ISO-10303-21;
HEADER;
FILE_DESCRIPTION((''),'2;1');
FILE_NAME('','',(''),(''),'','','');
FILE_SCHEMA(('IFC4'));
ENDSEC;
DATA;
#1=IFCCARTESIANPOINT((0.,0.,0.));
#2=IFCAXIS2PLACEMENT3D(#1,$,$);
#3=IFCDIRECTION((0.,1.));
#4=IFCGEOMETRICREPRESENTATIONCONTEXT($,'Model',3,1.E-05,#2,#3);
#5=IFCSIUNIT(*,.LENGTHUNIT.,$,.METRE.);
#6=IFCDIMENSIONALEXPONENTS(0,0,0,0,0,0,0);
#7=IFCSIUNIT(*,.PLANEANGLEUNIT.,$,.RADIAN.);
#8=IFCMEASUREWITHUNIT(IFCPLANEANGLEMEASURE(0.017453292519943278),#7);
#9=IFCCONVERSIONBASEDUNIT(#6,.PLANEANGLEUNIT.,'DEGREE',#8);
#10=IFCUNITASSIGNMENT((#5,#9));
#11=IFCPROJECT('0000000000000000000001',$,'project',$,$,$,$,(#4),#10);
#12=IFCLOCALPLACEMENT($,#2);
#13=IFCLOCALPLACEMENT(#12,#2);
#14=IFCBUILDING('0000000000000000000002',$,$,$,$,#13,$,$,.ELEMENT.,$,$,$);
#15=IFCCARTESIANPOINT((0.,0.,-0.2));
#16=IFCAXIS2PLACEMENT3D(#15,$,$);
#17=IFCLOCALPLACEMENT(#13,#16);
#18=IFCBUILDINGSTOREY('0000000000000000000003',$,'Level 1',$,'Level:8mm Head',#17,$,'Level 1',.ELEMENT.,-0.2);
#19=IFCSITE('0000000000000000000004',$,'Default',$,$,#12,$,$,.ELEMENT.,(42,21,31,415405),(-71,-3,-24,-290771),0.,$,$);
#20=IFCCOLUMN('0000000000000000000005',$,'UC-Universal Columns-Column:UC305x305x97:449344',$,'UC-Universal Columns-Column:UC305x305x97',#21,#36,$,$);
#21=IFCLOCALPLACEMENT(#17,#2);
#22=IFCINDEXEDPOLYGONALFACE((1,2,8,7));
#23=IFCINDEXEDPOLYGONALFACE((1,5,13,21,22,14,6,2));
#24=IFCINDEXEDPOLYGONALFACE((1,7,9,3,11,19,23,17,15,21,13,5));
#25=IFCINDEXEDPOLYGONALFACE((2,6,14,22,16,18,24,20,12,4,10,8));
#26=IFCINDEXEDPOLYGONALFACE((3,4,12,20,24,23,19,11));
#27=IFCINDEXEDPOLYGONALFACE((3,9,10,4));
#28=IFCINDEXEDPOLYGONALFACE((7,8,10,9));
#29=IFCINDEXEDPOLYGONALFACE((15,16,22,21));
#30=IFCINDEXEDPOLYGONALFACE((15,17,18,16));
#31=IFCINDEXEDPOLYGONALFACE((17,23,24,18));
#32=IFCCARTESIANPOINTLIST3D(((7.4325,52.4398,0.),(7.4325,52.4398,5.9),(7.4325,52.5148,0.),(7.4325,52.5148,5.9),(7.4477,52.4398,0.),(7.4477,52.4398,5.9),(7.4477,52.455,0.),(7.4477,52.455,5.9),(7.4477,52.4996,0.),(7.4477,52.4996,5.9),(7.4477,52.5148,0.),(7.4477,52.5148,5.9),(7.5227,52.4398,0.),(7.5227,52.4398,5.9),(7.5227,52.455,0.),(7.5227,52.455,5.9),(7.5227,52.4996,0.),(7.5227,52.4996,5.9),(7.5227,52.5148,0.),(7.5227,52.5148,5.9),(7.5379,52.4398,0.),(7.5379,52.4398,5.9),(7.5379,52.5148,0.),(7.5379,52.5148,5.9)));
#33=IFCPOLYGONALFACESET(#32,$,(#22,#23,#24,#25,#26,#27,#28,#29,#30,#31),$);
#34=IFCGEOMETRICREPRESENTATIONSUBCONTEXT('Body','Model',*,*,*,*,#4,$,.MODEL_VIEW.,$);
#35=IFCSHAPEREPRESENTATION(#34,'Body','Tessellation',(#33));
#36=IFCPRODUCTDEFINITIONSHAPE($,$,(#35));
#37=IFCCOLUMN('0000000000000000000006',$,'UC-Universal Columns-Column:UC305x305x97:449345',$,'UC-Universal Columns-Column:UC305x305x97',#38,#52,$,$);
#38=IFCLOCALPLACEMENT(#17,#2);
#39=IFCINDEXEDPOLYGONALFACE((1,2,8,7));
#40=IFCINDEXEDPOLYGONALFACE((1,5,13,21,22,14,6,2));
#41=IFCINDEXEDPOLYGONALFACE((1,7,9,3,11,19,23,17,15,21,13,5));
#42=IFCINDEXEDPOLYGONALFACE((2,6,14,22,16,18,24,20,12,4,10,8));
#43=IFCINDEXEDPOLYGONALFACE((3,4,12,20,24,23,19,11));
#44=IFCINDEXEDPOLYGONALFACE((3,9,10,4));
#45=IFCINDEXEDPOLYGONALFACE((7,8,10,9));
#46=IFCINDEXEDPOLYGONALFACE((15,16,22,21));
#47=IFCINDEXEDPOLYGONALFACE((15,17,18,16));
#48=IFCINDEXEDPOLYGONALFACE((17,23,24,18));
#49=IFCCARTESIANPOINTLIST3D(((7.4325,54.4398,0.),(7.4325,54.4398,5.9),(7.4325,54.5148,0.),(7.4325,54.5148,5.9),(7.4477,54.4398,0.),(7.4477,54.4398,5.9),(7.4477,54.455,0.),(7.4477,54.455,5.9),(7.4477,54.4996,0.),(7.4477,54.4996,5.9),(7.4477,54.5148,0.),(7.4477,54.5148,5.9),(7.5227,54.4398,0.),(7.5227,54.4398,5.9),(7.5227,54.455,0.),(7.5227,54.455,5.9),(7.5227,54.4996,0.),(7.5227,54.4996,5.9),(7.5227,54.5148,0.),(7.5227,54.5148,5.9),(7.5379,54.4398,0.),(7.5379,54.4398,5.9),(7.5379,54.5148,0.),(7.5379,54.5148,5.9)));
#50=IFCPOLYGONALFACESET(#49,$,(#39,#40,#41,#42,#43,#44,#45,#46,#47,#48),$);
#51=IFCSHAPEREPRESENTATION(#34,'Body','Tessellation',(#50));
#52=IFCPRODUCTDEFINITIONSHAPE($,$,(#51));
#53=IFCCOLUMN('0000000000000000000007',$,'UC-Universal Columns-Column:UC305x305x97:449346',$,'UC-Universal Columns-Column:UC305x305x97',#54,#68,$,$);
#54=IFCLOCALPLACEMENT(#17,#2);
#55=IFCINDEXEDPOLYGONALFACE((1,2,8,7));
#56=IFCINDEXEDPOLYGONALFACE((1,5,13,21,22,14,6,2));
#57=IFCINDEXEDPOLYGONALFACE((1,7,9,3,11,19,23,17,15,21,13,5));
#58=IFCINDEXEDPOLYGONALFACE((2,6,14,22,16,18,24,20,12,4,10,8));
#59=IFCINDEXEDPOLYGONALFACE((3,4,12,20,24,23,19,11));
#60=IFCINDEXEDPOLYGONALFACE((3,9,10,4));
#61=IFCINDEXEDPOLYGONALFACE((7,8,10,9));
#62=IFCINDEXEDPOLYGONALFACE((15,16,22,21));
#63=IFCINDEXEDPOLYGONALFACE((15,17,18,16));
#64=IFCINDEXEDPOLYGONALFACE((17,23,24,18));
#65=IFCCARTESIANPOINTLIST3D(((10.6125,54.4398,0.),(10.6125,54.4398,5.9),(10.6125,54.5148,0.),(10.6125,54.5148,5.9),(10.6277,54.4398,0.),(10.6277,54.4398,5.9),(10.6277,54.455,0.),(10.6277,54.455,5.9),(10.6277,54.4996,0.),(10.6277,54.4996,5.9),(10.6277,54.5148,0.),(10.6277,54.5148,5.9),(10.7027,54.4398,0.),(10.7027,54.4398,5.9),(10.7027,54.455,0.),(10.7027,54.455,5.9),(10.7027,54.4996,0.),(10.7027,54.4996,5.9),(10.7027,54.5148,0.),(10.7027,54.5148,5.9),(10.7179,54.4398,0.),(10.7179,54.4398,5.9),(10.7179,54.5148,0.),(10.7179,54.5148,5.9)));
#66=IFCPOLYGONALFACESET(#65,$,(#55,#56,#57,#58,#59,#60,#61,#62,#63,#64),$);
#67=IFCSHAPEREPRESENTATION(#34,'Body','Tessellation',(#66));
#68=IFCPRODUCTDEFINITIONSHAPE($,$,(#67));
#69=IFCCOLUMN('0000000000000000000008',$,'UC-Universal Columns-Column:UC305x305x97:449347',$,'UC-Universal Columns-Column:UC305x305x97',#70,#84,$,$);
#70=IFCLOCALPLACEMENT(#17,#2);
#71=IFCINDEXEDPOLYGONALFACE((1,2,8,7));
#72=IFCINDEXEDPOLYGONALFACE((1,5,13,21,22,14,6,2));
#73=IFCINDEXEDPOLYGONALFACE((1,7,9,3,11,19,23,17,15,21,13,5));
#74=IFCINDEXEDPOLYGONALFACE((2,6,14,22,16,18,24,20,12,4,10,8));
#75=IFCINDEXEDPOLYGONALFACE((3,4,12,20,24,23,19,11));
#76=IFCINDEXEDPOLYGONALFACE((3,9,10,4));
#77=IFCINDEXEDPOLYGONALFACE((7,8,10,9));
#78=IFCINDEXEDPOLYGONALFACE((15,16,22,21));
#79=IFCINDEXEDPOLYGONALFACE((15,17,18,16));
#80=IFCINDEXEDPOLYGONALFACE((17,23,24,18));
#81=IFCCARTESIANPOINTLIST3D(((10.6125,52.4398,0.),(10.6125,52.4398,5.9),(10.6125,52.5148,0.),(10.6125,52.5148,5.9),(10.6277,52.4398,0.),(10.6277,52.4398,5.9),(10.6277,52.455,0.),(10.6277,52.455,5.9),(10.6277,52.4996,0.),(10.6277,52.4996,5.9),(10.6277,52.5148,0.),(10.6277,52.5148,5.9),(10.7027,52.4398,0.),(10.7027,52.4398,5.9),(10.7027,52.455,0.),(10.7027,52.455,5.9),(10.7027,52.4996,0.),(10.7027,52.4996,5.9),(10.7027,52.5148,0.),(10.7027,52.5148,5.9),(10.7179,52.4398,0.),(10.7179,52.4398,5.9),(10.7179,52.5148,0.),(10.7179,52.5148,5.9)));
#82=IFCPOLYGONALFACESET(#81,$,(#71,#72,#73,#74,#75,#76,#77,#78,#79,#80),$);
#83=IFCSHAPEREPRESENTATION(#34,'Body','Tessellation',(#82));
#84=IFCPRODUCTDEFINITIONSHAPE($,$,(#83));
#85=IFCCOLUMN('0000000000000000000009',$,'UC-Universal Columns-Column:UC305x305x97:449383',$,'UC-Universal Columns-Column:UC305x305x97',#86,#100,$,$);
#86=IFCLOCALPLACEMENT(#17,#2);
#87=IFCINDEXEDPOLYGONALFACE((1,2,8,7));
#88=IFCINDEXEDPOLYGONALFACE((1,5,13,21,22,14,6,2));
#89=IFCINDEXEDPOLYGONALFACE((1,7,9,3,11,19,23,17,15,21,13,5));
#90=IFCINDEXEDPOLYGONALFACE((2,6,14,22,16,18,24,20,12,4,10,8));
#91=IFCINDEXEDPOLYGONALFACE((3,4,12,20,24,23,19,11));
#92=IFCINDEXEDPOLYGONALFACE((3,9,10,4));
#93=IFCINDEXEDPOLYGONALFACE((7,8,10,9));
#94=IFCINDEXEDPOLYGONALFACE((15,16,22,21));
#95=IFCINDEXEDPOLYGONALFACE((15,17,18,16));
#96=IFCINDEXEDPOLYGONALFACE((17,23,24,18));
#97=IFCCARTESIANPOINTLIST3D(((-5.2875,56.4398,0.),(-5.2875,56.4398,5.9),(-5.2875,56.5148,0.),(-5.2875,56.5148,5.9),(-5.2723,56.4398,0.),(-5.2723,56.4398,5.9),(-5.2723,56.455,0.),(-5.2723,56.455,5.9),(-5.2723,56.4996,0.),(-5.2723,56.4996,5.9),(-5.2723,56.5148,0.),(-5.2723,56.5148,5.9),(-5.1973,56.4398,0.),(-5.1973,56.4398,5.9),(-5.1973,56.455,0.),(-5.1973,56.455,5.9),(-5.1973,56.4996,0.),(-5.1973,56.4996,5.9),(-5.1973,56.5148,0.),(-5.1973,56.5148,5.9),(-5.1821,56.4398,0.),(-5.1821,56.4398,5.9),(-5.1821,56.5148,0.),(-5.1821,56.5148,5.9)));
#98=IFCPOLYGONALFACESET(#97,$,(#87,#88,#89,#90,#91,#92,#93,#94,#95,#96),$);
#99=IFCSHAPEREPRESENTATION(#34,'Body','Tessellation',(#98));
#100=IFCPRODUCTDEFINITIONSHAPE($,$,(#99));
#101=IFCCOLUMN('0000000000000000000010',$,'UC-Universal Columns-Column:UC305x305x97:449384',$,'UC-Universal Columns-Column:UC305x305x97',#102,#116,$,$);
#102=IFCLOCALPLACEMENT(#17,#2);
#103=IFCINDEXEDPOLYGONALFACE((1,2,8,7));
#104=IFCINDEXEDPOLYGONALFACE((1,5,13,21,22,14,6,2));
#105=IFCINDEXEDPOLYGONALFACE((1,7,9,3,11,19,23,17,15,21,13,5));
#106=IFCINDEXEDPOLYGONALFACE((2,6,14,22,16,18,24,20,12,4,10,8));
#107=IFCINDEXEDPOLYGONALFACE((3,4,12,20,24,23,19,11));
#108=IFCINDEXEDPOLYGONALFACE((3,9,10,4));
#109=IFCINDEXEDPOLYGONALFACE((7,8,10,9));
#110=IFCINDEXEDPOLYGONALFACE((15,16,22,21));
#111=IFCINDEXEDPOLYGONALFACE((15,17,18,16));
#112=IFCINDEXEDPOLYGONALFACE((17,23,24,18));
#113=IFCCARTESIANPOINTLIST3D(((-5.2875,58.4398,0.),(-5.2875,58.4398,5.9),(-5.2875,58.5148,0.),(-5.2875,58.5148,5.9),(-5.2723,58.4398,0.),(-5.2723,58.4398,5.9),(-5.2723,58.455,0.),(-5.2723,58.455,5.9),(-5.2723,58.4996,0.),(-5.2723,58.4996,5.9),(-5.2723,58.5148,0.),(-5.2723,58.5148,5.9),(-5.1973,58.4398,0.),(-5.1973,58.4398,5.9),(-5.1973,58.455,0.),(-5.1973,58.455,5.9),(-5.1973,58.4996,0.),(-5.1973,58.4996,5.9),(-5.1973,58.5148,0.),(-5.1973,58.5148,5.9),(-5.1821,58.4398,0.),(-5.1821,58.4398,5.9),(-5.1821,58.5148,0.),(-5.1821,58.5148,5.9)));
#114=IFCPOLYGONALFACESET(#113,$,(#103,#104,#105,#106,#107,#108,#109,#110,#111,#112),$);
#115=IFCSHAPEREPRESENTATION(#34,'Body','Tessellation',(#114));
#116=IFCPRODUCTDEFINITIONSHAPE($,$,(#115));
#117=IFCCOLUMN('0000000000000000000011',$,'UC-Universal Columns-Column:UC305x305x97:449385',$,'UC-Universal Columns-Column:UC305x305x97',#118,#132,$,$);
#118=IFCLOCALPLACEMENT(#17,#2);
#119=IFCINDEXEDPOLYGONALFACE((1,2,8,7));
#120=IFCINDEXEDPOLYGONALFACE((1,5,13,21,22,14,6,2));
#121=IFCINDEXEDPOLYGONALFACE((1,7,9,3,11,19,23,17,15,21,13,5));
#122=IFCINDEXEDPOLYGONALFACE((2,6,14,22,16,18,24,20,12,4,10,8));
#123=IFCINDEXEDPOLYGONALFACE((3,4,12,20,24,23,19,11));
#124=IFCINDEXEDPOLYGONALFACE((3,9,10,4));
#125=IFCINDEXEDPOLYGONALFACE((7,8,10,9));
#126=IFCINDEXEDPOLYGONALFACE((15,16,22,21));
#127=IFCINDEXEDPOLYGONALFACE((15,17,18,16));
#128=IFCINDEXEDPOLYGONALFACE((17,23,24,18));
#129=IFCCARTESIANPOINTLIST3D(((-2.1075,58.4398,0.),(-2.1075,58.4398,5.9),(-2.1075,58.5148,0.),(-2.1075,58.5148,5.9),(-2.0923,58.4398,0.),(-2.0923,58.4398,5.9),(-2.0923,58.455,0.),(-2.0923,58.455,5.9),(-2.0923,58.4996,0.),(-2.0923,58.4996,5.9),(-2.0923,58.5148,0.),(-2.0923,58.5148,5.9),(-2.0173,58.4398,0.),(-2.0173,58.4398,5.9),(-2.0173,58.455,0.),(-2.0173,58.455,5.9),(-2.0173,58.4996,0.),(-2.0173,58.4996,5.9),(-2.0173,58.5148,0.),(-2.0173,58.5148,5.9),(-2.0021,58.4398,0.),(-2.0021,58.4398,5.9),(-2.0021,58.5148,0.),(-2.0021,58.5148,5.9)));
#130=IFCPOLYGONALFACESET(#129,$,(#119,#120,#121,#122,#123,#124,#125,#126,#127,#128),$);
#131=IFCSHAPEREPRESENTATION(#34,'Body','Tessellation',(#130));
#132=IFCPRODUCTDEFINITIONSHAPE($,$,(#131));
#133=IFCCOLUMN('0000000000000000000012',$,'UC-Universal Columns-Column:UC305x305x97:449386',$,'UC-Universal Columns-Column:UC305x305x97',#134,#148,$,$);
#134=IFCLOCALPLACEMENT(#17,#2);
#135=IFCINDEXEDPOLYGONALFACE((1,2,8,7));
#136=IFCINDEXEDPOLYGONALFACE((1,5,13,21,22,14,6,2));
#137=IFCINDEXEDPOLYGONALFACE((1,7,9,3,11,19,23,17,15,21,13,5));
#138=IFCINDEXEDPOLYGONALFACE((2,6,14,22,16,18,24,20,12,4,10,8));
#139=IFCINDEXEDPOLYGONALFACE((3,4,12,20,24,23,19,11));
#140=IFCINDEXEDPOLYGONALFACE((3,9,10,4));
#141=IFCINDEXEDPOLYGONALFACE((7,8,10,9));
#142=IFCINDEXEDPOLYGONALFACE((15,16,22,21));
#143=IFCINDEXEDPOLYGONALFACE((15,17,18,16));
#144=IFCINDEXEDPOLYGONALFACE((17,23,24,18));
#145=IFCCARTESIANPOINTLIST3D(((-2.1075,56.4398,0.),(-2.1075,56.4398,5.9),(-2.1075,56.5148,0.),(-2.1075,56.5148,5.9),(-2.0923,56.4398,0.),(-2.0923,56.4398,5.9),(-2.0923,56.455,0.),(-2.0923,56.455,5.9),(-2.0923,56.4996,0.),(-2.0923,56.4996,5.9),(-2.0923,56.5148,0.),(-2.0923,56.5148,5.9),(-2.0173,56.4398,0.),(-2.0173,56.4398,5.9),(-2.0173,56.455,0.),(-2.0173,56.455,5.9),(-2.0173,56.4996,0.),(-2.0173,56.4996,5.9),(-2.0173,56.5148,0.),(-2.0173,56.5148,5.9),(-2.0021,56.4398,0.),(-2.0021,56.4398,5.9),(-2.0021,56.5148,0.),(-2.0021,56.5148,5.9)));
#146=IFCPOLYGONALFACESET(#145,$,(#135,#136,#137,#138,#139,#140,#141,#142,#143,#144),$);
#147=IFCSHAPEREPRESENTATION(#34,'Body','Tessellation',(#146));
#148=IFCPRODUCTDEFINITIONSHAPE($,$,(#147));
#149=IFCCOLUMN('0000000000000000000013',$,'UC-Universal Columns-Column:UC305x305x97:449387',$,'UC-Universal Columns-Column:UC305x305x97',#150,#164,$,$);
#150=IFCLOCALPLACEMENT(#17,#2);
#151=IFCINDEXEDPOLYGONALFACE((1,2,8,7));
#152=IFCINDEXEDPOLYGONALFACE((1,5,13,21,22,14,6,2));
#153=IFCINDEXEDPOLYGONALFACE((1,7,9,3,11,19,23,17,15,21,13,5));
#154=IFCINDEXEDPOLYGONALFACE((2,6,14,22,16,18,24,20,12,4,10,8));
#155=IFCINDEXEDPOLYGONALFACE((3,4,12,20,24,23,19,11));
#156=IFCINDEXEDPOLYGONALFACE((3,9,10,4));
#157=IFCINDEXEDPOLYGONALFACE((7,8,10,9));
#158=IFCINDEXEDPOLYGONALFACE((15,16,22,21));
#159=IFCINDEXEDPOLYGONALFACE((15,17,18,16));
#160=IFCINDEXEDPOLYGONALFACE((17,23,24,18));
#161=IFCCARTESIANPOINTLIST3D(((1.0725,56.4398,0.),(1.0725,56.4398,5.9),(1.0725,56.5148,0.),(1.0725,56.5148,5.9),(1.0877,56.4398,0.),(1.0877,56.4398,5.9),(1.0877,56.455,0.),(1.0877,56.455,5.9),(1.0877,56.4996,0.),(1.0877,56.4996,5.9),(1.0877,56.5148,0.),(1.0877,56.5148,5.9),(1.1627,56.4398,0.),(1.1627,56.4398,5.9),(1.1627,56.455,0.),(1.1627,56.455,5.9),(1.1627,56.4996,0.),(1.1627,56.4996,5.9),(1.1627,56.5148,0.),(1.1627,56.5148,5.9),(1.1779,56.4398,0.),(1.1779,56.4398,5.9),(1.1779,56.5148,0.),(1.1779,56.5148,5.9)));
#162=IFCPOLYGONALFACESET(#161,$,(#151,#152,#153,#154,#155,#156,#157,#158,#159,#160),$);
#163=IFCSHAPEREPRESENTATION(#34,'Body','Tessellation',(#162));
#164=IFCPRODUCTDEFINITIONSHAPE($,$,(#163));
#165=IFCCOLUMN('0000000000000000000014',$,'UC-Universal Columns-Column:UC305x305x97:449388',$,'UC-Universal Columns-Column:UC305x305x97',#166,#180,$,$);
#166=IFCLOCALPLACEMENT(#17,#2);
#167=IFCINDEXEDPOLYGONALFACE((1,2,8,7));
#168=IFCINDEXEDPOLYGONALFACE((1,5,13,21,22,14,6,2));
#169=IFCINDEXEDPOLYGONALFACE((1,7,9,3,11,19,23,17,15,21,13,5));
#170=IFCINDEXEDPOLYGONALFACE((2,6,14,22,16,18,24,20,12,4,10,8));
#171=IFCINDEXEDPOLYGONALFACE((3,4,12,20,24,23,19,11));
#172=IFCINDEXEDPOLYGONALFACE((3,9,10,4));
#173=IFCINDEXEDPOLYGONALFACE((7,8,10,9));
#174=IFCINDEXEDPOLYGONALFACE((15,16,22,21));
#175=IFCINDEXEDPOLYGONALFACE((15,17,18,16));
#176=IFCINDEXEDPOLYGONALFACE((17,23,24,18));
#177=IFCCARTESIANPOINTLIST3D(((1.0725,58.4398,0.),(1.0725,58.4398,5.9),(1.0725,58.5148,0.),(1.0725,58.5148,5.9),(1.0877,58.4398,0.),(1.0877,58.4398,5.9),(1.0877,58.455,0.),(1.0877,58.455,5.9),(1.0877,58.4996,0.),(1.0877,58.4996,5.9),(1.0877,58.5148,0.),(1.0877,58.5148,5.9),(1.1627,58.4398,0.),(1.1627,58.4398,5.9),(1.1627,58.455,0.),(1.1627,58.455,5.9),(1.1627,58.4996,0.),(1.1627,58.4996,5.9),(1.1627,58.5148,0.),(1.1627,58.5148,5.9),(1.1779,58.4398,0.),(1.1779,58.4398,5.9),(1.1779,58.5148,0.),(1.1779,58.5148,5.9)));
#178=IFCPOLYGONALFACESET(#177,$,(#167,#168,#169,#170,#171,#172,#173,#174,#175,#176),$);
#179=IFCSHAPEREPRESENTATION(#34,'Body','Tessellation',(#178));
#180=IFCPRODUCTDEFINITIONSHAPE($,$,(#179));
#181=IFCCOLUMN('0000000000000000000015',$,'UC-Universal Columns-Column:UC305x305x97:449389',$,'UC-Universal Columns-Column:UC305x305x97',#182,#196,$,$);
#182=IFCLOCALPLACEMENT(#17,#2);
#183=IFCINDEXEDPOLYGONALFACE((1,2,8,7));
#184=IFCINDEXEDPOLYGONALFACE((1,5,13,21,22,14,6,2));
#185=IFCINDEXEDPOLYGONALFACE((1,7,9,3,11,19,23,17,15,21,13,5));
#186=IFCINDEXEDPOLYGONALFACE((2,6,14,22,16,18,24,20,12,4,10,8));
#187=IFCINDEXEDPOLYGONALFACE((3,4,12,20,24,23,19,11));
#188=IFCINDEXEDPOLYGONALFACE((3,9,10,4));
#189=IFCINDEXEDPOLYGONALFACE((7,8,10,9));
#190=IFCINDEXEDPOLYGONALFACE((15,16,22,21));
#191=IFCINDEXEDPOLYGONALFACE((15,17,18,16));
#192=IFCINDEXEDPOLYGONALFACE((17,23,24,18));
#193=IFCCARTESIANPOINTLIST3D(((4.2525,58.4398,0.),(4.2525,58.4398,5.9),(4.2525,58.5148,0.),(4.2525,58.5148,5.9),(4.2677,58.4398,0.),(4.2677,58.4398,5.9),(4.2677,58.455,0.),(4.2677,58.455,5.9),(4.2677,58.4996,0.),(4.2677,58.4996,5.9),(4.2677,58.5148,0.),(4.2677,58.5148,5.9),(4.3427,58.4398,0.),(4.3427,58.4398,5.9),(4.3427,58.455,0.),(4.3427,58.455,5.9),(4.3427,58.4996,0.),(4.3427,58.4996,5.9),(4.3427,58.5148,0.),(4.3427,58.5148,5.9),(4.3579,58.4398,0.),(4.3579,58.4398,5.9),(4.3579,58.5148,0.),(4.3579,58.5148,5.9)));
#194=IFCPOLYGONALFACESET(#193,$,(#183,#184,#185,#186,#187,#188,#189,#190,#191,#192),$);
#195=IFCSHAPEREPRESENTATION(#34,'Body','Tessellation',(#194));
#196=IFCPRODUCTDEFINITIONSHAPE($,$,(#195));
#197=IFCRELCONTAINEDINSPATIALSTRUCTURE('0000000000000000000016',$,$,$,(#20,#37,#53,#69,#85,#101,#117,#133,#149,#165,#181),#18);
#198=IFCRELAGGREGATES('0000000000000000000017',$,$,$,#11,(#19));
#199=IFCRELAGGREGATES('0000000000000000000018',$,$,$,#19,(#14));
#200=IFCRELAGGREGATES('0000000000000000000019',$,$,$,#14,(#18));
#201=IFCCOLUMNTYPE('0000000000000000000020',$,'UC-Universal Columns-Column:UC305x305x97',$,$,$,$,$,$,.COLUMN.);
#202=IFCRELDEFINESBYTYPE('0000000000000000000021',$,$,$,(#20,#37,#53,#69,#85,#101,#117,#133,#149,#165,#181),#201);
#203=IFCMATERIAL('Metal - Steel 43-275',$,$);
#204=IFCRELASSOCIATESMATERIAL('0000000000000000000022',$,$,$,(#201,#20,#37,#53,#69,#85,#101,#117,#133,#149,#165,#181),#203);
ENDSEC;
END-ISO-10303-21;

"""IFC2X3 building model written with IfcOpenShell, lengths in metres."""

from ifc_helpers import new_model, entity, si_unit, converted_unit, direction, frame, frame_2d, origin, place, context, subcontext, project, spatial, polyline, circle_curve, parameter, trimmed, segment, composite_curve, outline, extrude, source, transform, mapped, material, type_object, type_shapes, element, save


model = new_model("IFC2X3")

# Units and contexts
model_context = context("Model", 3, precision=1e-05, world=origin(), true_north=direction((0.0, 1.0)))
body_context = subcontext(model_context, "Body", "Model", "MODEL_VIEW")
ifc_project = project(units=[si_unit("LENGTHUNIT", "METRE"), converted_unit("PLANEANGLEUNIT", "DEGREE", entity("IfcPlaneAngleMeasure", 0.017453292519943278), si_unit("PLANEANGLEUNIT", "RADIAN"), dimensions=[0, 0, 0, 0, 0, 0, 0])], contexts=[model_context])

# Site, building, storey
site_placement = place(None, origin())
site = spatial("IfcSite", under=ifc_project, at=site_placement, Name="Default", CompositionType="ELEMENT", RefLatitude=(42, 21, 31, 415405), RefLongitude=(-71, -3, -24, -290771), RefElevation=0.0)
building_placement = place(site_placement, origin())
building = spatial("IfcBuilding", under=site, at=building_placement, CompositionType="ELEMENT")
storey_placement = place(building_placement, frame((0.0, 0.0, -0.2)))
storey = spatial("IfcBuildingStorey", under=building, at=storey_placement, Name="Level 1", ObjectType="Level:8mm Head", LongName="Level 1", CompositionType="ELEMENT", Elevation=-0.2)

# Columns
ifc_material = material(Name="Metal - Steel 43-275")
column_type = type_object("IfcColumnType", Name="UC-Universal Columns-Column:UC305x305x97", PredefinedType="COLUMN", material=ifc_material)
shared_shape = source(origin(), body_context, "Body", "SweptSolid", [
    extrude(outline(composite_curve([segment(polyline([(-0.0375, -0.0375), (0.0375, -0.0375)]), True, "CONTINUOUS"), segment(polyline([(0.0375, -0.0375), (0.0527, -0.0375)]), True, "CONTINUOUS"), segment(trimmed(circle_curve(frame_2d((0.0527, -0.0223), x_axis=(-1.0, 0.0)), 0.0152), [parameter(0.0)], [parameter(90.0)], True, "PARAMETER"), False, "CONTINUOUS"), segment(polyline([(0.0375, -0.0223), (0.0375, 0.0223)]), True, "CONTINUOUS"), segment(trimmed(circle_curve(frame_2d((0.0527, 0.0223), x_axis=(-1.0, 0.0)), 0.0152), [parameter(270.0)], [parameter(0.0)], True, "PARAMETER"), False, "CONTINUOUS"), segment(polyline([(0.0527, 0.0375), (0.0375, 0.0375)]), True, "CONTINUOUS"), segment(polyline([(0.0375, 0.0375), (-0.0375, 0.0375)]), True, "CONTINUOUS"), segment(polyline([(-0.0375, 0.0375), (-0.0527, 0.0375)]), True, "CONTINUOUS"), segment(trimmed(circle_curve(frame_2d((-0.0527, 0.0223), x_axis=(-1.0, 0.0)), 0.0152), [parameter(180.0)], [parameter(270.0)], True, "PARAMETER"), False, "CONTINUOUS"), segment(polyline([(-0.0375, 0.0223), (-0.0375, -0.0223)]), True, "CONTINUOUS"), segment(trimmed(circle_curve(frame_2d((-0.0527, -0.0223), x_axis=(-1.0, 0.0)), 0.0152), [parameter(90.0)], [parameter(180.0)], True, "PARAMETER"), False, "CONTINUOUS"), segment(polyline([(-0.0527, -0.0375), (-0.0375, -0.0375)]), True, "CONTINUOUS")], self_intersect=False)), frame((0.0, 0.0, -0.2), z_axis=(0.0, 0.0, 1.0), x_axis=(-1.0, 0.0, 0.0)), (0.0, 0.0, 1.0), 5.9),
])
type_shapes(column_type, [shared_shape])
for number, where, z_axis, x_axis, name in (
    (1, (7.4852, 52.4773, 0.2), (0.0, 0.0, 1.0), (-1.0, 0.0, 0.0), "UC-Universal Columns-Column:UC305x305x97:449344"),
    (2, (7.4852, 54.4773, 0.2), (0.0, 0.0, 1.0), (-1.0, 0.0, 0.0), "UC-Universal Columns-Column:UC305x305x97:449345"),
    (3, (10.6652, 54.4773, 0.2), (0.0, 0.0, 1.0), (-1.0, 0.0, 0.0), "UC-Universal Columns-Column:UC305x305x97:449346"),
    (4, (10.6652, 52.4773, 0.2), (0.0, 0.0, 1.0), (-1.0, 0.0, 0.0), "UC-Universal Columns-Column:UC305x305x97:449347"),
    (5, (-5.2348, 56.4773, 0.2), (0.0, 0.0, 1.0), (-1.0, 0.0, 0.0), "UC-Universal Columns-Column:UC305x305x97:449383"),
    (6, (-5.2348, 58.4773, 0.2), (0.0, 0.0, 1.0), (-1.0, 0.0, 0.0), "UC-Universal Columns-Column:UC305x305x97:449384"),
    (7, (-2.0548, 58.4773, 0.2), (0.0, 0.0, 1.0), (-1.0, 0.0, 0.0), "UC-Universal Columns-Column:UC305x305x97:449385"),
    (8, (-2.0548, 56.4773, 0.2), (0.0, 0.0, 1.0), (-1.0, 0.0, 0.0), "UC-Universal Columns-Column:UC305x305x97:449386"),
    (9, (1.1252, 56.4773, 0.2), (0.0, 0.0, 1.0), (-1.0, 0.0, 0.0), "UC-Universal Columns-Column:UC305x305x97:449387"),
    (10, (1.1252, 58.4773, 0.2), (0.0, 0.0, 1.0), (-1.0, 0.0, 0.0), "UC-Universal Columns-Column:UC305x305x97:449388"),
    (11, (4.3052, 58.4773, 0.2), (0.0, 0.0, 1.0), (-1.0, 0.0, 0.0), "UC-Universal Columns-Column:UC305x305x97:449389"),
):
    element("IfcColumn", number, at=place(storey_placement, frame(where, z_axis=z_axis, x_axis=x_axis)), inside=storey, type_object=column_type, material=ifc_material, Name=name, ObjectType="UC-Universal Columns-Column:UC305x305x97", context=body_context, shape_type="MappedRepresentation", body=[
        mapped(shared_shape, transform((0.0, 0.0, 0.0), scale=1.0)),
    ])

save(model, "model.ifc")
